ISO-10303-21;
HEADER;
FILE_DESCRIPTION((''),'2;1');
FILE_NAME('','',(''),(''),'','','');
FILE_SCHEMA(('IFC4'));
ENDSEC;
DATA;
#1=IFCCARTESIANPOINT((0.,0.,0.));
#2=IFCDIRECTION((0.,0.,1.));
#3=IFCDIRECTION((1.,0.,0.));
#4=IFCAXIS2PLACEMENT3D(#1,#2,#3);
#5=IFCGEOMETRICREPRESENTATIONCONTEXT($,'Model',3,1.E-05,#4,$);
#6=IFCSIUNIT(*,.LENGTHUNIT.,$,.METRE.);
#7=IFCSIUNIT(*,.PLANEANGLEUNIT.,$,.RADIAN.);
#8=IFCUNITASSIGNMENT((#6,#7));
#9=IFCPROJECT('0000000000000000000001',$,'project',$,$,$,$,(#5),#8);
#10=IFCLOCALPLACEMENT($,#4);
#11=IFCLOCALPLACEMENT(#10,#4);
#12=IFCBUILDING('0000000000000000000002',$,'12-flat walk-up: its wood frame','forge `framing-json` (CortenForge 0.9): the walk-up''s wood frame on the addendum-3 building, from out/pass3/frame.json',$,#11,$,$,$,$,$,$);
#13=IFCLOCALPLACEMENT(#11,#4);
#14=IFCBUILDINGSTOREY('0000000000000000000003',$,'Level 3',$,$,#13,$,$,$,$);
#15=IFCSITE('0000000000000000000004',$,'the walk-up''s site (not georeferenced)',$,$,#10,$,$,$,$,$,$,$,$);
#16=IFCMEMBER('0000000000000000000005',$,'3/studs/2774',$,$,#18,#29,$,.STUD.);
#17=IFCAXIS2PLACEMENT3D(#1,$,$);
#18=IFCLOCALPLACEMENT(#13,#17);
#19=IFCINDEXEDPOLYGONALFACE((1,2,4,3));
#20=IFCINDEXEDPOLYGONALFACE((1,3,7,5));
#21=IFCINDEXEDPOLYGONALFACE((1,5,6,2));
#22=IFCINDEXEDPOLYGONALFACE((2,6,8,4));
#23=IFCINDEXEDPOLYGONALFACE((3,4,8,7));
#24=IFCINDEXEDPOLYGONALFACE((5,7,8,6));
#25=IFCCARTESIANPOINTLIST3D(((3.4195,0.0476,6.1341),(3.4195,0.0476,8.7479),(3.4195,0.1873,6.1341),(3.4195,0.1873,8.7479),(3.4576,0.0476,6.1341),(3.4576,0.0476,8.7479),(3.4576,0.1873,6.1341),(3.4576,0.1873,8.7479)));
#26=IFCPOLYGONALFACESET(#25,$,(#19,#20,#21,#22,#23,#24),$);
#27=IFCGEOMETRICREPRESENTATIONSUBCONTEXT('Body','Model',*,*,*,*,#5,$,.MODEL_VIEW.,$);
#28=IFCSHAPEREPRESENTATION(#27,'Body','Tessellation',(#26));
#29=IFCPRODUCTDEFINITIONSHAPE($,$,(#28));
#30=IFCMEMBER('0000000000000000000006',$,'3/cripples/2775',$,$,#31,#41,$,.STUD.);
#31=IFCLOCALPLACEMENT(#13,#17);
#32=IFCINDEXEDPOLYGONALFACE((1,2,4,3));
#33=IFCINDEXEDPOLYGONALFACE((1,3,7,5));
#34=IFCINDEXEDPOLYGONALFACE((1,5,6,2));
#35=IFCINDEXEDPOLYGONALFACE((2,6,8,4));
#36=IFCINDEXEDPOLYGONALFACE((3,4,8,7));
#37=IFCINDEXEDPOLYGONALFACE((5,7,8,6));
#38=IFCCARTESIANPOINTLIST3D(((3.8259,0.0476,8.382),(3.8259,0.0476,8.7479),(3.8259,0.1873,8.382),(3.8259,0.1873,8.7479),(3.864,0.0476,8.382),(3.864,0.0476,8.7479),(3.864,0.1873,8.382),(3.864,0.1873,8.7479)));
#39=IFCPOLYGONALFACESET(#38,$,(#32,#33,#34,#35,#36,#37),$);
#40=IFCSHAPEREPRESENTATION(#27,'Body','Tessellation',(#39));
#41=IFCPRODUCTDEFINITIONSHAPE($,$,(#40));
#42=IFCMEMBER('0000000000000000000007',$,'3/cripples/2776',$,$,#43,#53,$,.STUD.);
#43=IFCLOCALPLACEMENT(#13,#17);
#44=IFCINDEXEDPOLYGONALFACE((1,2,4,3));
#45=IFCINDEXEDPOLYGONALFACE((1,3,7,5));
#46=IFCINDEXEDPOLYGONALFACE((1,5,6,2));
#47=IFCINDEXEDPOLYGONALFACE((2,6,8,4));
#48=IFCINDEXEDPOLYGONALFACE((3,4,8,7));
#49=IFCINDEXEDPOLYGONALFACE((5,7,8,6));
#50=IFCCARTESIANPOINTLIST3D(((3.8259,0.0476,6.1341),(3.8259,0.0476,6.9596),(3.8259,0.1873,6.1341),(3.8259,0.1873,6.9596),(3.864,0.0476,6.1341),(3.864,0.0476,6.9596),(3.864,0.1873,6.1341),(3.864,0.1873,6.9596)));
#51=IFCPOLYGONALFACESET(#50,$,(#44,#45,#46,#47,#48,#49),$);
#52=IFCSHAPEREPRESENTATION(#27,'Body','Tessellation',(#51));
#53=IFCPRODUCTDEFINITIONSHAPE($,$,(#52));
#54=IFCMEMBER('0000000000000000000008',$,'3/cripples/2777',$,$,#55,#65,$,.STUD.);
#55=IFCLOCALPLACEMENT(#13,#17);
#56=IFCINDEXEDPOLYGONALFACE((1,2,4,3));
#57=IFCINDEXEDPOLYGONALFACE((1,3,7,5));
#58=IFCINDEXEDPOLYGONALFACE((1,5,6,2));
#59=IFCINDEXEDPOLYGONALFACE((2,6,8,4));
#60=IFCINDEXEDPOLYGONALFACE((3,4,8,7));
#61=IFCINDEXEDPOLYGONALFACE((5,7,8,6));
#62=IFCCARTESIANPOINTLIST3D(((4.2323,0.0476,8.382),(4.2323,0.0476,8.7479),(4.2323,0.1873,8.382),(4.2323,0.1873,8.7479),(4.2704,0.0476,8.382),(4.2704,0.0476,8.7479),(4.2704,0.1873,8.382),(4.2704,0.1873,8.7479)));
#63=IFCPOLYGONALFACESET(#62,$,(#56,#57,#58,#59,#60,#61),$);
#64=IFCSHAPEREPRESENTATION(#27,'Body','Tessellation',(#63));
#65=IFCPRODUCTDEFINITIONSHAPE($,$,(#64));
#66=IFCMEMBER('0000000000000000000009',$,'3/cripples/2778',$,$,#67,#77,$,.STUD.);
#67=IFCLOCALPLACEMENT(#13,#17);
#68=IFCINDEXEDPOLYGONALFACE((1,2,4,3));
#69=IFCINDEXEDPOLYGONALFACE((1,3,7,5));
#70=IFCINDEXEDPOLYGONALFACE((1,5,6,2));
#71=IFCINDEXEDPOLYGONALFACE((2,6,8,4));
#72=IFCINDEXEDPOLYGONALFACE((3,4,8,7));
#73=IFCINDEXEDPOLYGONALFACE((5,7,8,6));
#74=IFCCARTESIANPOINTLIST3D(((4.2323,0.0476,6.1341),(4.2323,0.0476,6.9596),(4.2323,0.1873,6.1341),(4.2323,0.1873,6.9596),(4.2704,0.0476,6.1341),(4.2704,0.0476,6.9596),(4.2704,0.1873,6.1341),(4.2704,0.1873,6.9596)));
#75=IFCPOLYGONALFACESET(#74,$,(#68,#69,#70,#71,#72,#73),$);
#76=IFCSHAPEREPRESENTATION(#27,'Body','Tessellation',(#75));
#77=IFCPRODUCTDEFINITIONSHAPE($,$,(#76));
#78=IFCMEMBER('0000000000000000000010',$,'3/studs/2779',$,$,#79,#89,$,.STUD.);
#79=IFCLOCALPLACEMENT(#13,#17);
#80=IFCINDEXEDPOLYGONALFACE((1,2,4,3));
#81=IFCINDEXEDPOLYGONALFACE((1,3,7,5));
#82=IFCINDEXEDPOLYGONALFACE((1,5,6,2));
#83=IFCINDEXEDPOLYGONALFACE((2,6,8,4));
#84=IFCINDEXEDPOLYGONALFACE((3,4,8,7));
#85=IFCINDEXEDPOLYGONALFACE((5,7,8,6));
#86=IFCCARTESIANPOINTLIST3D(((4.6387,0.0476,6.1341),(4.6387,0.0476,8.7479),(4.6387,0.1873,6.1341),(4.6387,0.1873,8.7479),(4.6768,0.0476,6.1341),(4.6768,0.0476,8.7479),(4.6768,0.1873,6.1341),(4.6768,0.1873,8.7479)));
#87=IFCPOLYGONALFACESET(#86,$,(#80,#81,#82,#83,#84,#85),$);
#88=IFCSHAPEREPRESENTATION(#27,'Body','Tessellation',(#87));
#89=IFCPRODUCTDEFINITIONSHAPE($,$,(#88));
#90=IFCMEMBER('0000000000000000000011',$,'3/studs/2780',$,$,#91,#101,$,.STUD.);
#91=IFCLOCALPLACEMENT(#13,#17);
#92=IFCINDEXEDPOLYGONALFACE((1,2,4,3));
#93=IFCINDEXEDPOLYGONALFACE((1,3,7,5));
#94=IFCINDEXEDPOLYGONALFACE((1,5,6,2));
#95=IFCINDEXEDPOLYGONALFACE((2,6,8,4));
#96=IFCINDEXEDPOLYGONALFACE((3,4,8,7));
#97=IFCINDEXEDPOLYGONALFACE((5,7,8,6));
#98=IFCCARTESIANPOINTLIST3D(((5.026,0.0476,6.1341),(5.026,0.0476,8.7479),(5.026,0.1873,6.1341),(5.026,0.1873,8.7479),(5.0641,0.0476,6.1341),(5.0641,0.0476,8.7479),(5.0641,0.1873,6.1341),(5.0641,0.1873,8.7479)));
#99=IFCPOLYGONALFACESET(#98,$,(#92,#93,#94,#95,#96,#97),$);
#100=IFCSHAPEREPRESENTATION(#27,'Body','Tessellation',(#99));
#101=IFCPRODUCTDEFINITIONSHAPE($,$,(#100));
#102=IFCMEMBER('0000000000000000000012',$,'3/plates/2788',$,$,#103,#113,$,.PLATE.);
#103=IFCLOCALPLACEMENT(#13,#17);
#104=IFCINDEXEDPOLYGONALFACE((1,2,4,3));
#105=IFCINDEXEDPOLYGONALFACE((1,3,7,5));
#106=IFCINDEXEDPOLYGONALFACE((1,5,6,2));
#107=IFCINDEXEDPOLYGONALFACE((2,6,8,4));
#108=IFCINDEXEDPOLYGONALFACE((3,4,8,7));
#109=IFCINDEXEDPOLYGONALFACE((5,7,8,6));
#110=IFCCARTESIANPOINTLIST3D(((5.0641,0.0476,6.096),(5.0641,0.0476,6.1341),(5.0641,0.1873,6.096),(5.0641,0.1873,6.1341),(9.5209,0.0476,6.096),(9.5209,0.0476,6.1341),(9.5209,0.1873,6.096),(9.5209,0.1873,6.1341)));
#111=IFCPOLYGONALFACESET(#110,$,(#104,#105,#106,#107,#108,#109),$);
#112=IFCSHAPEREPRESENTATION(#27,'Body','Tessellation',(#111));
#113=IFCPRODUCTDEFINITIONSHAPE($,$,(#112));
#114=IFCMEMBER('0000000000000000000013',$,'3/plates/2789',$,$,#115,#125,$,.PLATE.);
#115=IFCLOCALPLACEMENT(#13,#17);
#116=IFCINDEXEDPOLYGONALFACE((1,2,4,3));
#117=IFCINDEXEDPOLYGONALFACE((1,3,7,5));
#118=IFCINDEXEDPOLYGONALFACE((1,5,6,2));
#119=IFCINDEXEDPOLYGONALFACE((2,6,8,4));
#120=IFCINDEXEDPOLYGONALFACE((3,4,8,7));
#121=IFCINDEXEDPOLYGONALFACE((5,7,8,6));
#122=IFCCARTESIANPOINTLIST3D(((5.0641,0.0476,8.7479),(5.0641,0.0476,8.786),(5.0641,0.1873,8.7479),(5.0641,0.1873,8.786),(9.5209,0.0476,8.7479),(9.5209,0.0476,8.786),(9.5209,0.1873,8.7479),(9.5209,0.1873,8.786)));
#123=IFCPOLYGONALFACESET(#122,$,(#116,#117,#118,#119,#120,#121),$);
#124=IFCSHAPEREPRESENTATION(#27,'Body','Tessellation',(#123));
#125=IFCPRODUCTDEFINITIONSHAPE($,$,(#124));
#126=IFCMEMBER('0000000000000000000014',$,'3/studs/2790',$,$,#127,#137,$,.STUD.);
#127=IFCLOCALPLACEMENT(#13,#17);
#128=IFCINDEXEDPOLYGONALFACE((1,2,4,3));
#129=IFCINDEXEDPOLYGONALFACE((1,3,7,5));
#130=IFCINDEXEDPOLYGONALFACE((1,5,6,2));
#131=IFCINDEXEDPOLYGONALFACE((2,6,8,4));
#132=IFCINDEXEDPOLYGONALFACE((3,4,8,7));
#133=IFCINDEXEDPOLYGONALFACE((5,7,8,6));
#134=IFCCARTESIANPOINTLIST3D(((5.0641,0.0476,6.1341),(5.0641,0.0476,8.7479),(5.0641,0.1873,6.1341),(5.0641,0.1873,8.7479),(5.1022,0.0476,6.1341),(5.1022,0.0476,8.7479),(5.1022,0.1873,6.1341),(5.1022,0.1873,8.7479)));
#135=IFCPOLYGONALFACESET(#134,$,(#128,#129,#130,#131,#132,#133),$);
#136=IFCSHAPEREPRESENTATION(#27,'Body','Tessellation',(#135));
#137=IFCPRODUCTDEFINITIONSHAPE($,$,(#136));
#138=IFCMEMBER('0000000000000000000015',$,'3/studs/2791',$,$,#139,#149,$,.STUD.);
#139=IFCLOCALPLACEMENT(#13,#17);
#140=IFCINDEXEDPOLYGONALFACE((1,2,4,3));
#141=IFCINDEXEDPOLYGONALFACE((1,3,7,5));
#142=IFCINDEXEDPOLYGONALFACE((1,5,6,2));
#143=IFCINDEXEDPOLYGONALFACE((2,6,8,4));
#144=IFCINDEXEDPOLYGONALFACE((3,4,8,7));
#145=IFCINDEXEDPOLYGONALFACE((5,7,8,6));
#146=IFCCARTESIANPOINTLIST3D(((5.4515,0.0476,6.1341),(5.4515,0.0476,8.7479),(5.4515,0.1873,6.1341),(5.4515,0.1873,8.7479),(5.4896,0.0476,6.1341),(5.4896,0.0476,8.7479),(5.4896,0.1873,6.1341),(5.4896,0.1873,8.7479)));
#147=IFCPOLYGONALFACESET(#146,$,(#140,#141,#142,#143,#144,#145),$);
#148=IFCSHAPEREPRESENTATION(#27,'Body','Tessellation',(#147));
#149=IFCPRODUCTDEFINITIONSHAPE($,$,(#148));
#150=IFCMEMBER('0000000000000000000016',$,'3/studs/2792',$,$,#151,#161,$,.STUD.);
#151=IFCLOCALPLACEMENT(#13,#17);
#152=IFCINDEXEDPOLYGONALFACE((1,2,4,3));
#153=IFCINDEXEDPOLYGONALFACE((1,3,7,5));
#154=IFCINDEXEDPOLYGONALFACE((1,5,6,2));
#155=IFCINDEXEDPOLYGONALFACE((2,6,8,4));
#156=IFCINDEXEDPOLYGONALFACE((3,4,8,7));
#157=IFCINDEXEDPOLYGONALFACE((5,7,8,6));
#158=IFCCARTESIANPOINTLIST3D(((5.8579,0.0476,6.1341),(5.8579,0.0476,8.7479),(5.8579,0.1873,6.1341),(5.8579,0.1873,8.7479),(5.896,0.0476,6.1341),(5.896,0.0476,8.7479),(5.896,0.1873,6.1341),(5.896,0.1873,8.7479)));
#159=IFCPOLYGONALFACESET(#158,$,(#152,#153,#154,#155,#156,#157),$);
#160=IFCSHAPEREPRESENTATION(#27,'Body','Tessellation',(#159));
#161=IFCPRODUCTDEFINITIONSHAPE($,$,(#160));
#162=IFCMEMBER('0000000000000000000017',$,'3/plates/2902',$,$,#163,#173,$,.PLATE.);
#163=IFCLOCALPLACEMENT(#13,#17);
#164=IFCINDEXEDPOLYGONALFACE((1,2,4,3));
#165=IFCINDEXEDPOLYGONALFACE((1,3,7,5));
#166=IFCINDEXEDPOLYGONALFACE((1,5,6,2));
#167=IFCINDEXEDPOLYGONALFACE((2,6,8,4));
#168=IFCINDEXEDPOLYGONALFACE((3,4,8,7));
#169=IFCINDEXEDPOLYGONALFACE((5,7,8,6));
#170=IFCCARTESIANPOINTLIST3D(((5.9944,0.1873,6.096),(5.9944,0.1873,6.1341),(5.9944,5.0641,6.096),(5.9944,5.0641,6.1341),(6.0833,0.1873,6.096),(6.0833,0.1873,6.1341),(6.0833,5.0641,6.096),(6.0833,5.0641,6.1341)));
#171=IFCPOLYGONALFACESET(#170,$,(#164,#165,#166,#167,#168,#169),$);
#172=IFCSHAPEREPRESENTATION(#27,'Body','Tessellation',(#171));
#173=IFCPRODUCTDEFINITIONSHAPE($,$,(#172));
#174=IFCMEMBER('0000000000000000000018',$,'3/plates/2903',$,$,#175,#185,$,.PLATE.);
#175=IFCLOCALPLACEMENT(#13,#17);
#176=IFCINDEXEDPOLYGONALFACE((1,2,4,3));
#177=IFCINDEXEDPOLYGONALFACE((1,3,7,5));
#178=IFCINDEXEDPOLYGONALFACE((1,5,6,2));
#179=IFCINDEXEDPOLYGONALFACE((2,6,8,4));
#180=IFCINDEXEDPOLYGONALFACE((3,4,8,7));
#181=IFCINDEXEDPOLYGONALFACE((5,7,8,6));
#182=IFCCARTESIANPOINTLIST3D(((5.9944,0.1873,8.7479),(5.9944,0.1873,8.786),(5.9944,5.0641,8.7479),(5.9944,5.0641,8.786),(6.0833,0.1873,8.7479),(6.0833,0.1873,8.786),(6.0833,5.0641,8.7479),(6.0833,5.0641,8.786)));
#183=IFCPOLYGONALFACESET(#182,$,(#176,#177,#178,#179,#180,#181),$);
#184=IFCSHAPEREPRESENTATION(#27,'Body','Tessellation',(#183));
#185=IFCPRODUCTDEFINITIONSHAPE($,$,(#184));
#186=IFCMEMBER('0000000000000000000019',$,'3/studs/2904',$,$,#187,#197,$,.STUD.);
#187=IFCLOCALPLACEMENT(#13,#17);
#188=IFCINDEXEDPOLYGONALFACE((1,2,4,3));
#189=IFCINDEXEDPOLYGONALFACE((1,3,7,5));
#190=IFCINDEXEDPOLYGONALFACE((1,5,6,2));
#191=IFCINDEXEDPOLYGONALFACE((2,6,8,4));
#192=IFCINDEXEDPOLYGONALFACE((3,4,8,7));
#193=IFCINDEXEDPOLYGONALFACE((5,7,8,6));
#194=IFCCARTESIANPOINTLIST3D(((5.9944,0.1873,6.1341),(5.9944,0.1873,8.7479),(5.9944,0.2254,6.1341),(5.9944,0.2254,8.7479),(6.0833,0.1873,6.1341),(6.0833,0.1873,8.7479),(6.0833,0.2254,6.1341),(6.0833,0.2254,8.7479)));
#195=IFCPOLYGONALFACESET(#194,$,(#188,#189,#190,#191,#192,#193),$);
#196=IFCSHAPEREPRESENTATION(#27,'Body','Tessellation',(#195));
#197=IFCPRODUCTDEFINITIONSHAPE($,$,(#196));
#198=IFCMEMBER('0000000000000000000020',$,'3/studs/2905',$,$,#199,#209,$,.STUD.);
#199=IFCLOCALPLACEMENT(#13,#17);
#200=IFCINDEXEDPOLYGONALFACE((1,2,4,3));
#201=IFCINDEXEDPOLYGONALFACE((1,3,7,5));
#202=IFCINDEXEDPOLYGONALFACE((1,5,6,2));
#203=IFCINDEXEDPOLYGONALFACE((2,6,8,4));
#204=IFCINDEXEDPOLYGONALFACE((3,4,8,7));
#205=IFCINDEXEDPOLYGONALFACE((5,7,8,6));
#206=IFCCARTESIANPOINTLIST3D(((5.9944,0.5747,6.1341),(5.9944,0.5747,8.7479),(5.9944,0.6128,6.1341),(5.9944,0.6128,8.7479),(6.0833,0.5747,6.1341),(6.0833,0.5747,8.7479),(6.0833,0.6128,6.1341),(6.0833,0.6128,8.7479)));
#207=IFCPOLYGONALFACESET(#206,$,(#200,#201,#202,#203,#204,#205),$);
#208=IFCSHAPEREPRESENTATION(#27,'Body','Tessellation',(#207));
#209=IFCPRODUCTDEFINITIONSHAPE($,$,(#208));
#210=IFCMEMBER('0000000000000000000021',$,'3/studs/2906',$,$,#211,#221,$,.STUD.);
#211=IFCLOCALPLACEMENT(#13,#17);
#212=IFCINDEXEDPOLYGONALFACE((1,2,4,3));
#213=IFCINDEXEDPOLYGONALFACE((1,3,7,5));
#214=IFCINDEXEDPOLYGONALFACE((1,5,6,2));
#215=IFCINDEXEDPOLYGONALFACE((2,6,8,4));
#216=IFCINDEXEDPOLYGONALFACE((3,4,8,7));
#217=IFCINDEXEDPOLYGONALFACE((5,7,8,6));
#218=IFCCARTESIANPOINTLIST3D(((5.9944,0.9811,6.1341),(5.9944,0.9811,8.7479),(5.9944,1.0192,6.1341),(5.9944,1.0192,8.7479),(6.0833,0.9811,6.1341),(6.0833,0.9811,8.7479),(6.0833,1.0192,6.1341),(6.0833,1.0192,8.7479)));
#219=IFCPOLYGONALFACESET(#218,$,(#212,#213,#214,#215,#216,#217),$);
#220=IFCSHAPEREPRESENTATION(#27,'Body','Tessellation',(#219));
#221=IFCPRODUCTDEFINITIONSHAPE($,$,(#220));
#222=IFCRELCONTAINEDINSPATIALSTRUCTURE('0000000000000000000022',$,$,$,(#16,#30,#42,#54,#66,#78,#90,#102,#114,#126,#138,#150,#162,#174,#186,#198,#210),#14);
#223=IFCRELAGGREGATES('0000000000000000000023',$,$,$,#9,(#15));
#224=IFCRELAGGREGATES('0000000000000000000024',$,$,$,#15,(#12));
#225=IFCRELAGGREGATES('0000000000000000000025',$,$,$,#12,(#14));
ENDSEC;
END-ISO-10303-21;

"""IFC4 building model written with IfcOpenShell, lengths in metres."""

from ifc_helpers import new_model, si_unit, frame, frame_2d, origin, origin_with_axes, place, context, subcontext, project, spatial, rectangle, extrude, element, save


model = new_model("IFC4")

# Units and contexts
model_context = context("Model", 3, precision=1e-05, world=origin_with_axes())
body_context = subcontext(model_context, "Body", "Model", "MODEL_VIEW")
ifc_project = project(units=[si_unit("LENGTHUNIT", "METRE"), si_unit("PLANEANGLEUNIT", "RADIAN")], contexts=[model_context])

# Site, building, storey
site_placement = place(None, origin_with_axes())
site = spatial("IfcSite", under=ifc_project, at=site_placement, Name="the walk-up's site (not georeferenced)")
building_placement = place(site_placement, origin_with_axes())
building = spatial("IfcBuilding", under=site, at=building_placement, Name="12-flat walk-up: its wood frame", Description="forge `framing-json` (CortenForge 0.9): the walk-up's wood frame on the addendum-3 building, from out/pass3/frame.json")
storey_placement = place(building_placement, origin_with_axes())
storey = spatial("IfcBuildingStorey", under=building, at=storey_placement, Name="Level 3")

# Members
for number, where, z_axis, x_axis, name in (
    (1, (3.4195, 0.0476, 6.1341), (0.0, 0.0, 1.0), (1.0, 0.0, 0.0), "3/studs/2774"),
):
    element("IfcMember", number, at=place(storey_placement, frame(where, z_axis=z_axis, x_axis=x_axis)), inside=storey, Name=name, PredefinedType="STUD", context=body_context, shape_type="SweptSolid", body=[
        extrude(rectangle(XDim=0.0381, YDim=0.1397, at=frame_2d((0.0191, 0.0698))), origin(), (0.0, 0.0, 1.0), 2.6138),
    ])
member_1_placement = place(storey_placement, frame((3.8259, 0.0476, 8.382), z_axis=(0.0, 0.0, 1.0), x_axis=(1.0, 0.0, 0.0)))
element("IfcMember", 2, at=member_1_placement, inside=storey, Name="3/cripples/2775", PredefinedType="STUD", context=body_context, shape_type="SweptSolid", body=[
    extrude(rectangle(XDim=0.0381, YDim=0.1397, at=frame_2d((0.0191, 0.0698))), origin(), (0.0, 0.0, 1.0), 0.3659),
])
member_2_placement = place(storey_placement, frame((3.8259, 0.0476, 6.1341), z_axis=(0.0, 0.0, 1.0), x_axis=(1.0, 0.0, 0.0)))
element("IfcMember", 3, at=member_2_placement, inside=storey, Name="3/cripples/2776", PredefinedType="STUD", context=body_context, shape_type="SweptSolid", body=[
    extrude(rectangle(XDim=0.0381, YDim=0.1397, at=frame_2d((0.0191, 0.0698))), origin(), (0.0, 0.0, 1.0), 0.8255),
])
member_3_placement = place(storey_placement, frame((4.2323, 0.0476, 8.382), z_axis=(0.0, 0.0, 1.0), x_axis=(1.0, 0.0, 0.0)))
element("IfcMember", 4, at=member_3_placement, inside=storey, Name="3/cripples/2777", PredefinedType="STUD", context=body_context, shape_type="SweptSolid", body=[
    extrude(rectangle(XDim=0.0381, YDim=0.1397, at=frame_2d((0.0191, 0.0698))), origin(), (0.0, 0.0, 1.0), 0.3659),
])
member_4_placement = place(storey_placement, frame((4.2323, 0.0476, 6.1341), z_axis=(0.0, 0.0, 1.0), x_axis=(1.0, 0.0, 0.0)))
element("IfcMember", 5, at=member_4_placement, inside=storey, Name="3/cripples/2778", PredefinedType="STUD", context=body_context, shape_type="SweptSolid", body=[
    extrude(rectangle(XDim=0.0381, YDim=0.1397, at=frame_2d((0.0191, 0.0698))), origin(), (0.0, 0.0, 1.0), 0.8255),
])
for number, where, z_axis, x_axis, name in (
    (6, (4.6387, 0.0476, 6.1341), (0.0, 0.0, 1.0), (1.0, 0.0, 0.0), "3/studs/2779"),
    (7, (5.026, 0.0476, 6.1341), (0.0, 0.0, 1.0), (1.0, 0.0, 0.0), "3/studs/2780"),
):
    element("IfcMember", number, at=place(storey_placement, frame(where, z_axis=z_axis, x_axis=x_axis)), inside=storey, Name=name, PredefinedType="STUD", context=body_context, shape_type="SweptSolid", body=[
        extrude(rectangle(XDim=0.0381, YDim=0.1397, at=frame_2d((0.0191, 0.0698))), origin(), (0.0, 0.0, 1.0), 2.6138),
    ])
for number, where, z_axis, x_axis, name in (
    (8, (5.0641, 0.0476, 6.096), (0.0, 0.0, 1.0), (1.0, 0.0, 0.0), "3/plates/2788"),
    (9, (5.0641, 0.0476, 8.7479), (0.0, 0.0, 1.0), (1.0, 0.0, 0.0), "3/plates/2789"),
):
    element("IfcMember", number, at=place(storey_placement, frame(where, z_axis=z_axis, x_axis=x_axis)), inside=storey, Name=name, PredefinedType="PLATE", context=body_context, shape_type="SweptSolid", body=[
        extrude(rectangle(XDim=4.4568, YDim=0.1397, at=frame_2d((2.2284, 0.0698))), origin(), (0.0, 0.0, 1.0), 0.0381),
    ])
for number, where, z_axis, x_axis, name in (
    (10, (5.0641, 0.0476, 6.1341), (0.0, 0.0, 1.0), (1.0, 0.0, 0.0), "3/studs/2790"),
    (11, (5.4515, 0.0476, 6.1341), (0.0, 0.0, 1.0), (1.0, 0.0, 0.0), "3/studs/2791"),
    (12, (5.8579, 0.0476, 6.1341), (0.0, 0.0, 1.0), (1.0, 0.0, 0.0), "3/studs/2792"),
):
    element("IfcMember", number, at=place(storey_placement, frame(where, z_axis=z_axis, x_axis=x_axis)), inside=storey, Name=name, PredefinedType="STUD", context=body_context, shape_type="SweptSolid", body=[
        extrude(rectangle(XDim=0.0381, YDim=0.1397, at=frame_2d((0.0191, 0.0698))), origin(), (0.0, 0.0, 1.0), 2.6138),
    ])
for number, where, z_axis, x_axis, name in (
    (13, (5.9944, 0.1873, 6.096), (0.0, 0.0, 1.0), (1.0, 0.0, 0.0), "3/plates/2902"),
    (14, (5.9944, 0.1873, 8.7479), (0.0, 0.0, 1.0), (1.0, 0.0, 0.0), "3/plates/2903"),
):
    element("IfcMember", number, at=place(storey_placement, frame(where, z_axis=z_axis, x_axis=x_axis)), inside=storey, Name=name, PredefinedType="PLATE", context=body_context, shape_type="SweptSolid", body=[
        extrude(rectangle(XDim=0.0889, YDim=4.8768, at=frame_2d((0.0445, 2.4384))), origin(), (0.0, 0.0, 1.0), 0.0381),
    ])
member_5_placement = place(storey_placement, frame((5.9944, 0.1873, 6.1341), z_axis=(0.0, 0.0, 1.0), x_axis=(1.0, 0.0, 0.0)))
element("IfcMember", 15, at=member_5_placement, inside=storey, Name="3/studs/2904", PredefinedType="STUD", context=body_context, shape_type="SweptSolid", body=[
    extrude(rectangle(XDim=0.0889, YDim=0.0381, at=frame_2d((0.0445, 0.019))), origin(), (0.0, 0.0, 1.0), 2.6138),
])
for number, where, z_axis, x_axis, name in (
    (16, (5.9944, 0.5747, 6.1341), (0.0, 0.0, 1.0), (1.0, 0.0, 0.0), "3/studs/2905"),
    (17, (5.9944, 0.9811, 6.1341), (0.0, 0.0, 1.0), (1.0, 0.0, 0.0), "3/studs/2906"),
):
    element("IfcMember", number, at=place(storey_placement, frame(where, z_axis=z_axis, x_axis=x_axis)), inside=storey, Name=name, PredefinedType="STUD", context=body_context, shape_type="SweptSolid", body=[
        extrude(rectangle(XDim=0.0889, YDim=0.0381, at=frame_2d((0.0445, 0.019))), origin(), (0.0, 0.0, 1.0), 2.6138),
    ])

save(model, "model.ifc")
